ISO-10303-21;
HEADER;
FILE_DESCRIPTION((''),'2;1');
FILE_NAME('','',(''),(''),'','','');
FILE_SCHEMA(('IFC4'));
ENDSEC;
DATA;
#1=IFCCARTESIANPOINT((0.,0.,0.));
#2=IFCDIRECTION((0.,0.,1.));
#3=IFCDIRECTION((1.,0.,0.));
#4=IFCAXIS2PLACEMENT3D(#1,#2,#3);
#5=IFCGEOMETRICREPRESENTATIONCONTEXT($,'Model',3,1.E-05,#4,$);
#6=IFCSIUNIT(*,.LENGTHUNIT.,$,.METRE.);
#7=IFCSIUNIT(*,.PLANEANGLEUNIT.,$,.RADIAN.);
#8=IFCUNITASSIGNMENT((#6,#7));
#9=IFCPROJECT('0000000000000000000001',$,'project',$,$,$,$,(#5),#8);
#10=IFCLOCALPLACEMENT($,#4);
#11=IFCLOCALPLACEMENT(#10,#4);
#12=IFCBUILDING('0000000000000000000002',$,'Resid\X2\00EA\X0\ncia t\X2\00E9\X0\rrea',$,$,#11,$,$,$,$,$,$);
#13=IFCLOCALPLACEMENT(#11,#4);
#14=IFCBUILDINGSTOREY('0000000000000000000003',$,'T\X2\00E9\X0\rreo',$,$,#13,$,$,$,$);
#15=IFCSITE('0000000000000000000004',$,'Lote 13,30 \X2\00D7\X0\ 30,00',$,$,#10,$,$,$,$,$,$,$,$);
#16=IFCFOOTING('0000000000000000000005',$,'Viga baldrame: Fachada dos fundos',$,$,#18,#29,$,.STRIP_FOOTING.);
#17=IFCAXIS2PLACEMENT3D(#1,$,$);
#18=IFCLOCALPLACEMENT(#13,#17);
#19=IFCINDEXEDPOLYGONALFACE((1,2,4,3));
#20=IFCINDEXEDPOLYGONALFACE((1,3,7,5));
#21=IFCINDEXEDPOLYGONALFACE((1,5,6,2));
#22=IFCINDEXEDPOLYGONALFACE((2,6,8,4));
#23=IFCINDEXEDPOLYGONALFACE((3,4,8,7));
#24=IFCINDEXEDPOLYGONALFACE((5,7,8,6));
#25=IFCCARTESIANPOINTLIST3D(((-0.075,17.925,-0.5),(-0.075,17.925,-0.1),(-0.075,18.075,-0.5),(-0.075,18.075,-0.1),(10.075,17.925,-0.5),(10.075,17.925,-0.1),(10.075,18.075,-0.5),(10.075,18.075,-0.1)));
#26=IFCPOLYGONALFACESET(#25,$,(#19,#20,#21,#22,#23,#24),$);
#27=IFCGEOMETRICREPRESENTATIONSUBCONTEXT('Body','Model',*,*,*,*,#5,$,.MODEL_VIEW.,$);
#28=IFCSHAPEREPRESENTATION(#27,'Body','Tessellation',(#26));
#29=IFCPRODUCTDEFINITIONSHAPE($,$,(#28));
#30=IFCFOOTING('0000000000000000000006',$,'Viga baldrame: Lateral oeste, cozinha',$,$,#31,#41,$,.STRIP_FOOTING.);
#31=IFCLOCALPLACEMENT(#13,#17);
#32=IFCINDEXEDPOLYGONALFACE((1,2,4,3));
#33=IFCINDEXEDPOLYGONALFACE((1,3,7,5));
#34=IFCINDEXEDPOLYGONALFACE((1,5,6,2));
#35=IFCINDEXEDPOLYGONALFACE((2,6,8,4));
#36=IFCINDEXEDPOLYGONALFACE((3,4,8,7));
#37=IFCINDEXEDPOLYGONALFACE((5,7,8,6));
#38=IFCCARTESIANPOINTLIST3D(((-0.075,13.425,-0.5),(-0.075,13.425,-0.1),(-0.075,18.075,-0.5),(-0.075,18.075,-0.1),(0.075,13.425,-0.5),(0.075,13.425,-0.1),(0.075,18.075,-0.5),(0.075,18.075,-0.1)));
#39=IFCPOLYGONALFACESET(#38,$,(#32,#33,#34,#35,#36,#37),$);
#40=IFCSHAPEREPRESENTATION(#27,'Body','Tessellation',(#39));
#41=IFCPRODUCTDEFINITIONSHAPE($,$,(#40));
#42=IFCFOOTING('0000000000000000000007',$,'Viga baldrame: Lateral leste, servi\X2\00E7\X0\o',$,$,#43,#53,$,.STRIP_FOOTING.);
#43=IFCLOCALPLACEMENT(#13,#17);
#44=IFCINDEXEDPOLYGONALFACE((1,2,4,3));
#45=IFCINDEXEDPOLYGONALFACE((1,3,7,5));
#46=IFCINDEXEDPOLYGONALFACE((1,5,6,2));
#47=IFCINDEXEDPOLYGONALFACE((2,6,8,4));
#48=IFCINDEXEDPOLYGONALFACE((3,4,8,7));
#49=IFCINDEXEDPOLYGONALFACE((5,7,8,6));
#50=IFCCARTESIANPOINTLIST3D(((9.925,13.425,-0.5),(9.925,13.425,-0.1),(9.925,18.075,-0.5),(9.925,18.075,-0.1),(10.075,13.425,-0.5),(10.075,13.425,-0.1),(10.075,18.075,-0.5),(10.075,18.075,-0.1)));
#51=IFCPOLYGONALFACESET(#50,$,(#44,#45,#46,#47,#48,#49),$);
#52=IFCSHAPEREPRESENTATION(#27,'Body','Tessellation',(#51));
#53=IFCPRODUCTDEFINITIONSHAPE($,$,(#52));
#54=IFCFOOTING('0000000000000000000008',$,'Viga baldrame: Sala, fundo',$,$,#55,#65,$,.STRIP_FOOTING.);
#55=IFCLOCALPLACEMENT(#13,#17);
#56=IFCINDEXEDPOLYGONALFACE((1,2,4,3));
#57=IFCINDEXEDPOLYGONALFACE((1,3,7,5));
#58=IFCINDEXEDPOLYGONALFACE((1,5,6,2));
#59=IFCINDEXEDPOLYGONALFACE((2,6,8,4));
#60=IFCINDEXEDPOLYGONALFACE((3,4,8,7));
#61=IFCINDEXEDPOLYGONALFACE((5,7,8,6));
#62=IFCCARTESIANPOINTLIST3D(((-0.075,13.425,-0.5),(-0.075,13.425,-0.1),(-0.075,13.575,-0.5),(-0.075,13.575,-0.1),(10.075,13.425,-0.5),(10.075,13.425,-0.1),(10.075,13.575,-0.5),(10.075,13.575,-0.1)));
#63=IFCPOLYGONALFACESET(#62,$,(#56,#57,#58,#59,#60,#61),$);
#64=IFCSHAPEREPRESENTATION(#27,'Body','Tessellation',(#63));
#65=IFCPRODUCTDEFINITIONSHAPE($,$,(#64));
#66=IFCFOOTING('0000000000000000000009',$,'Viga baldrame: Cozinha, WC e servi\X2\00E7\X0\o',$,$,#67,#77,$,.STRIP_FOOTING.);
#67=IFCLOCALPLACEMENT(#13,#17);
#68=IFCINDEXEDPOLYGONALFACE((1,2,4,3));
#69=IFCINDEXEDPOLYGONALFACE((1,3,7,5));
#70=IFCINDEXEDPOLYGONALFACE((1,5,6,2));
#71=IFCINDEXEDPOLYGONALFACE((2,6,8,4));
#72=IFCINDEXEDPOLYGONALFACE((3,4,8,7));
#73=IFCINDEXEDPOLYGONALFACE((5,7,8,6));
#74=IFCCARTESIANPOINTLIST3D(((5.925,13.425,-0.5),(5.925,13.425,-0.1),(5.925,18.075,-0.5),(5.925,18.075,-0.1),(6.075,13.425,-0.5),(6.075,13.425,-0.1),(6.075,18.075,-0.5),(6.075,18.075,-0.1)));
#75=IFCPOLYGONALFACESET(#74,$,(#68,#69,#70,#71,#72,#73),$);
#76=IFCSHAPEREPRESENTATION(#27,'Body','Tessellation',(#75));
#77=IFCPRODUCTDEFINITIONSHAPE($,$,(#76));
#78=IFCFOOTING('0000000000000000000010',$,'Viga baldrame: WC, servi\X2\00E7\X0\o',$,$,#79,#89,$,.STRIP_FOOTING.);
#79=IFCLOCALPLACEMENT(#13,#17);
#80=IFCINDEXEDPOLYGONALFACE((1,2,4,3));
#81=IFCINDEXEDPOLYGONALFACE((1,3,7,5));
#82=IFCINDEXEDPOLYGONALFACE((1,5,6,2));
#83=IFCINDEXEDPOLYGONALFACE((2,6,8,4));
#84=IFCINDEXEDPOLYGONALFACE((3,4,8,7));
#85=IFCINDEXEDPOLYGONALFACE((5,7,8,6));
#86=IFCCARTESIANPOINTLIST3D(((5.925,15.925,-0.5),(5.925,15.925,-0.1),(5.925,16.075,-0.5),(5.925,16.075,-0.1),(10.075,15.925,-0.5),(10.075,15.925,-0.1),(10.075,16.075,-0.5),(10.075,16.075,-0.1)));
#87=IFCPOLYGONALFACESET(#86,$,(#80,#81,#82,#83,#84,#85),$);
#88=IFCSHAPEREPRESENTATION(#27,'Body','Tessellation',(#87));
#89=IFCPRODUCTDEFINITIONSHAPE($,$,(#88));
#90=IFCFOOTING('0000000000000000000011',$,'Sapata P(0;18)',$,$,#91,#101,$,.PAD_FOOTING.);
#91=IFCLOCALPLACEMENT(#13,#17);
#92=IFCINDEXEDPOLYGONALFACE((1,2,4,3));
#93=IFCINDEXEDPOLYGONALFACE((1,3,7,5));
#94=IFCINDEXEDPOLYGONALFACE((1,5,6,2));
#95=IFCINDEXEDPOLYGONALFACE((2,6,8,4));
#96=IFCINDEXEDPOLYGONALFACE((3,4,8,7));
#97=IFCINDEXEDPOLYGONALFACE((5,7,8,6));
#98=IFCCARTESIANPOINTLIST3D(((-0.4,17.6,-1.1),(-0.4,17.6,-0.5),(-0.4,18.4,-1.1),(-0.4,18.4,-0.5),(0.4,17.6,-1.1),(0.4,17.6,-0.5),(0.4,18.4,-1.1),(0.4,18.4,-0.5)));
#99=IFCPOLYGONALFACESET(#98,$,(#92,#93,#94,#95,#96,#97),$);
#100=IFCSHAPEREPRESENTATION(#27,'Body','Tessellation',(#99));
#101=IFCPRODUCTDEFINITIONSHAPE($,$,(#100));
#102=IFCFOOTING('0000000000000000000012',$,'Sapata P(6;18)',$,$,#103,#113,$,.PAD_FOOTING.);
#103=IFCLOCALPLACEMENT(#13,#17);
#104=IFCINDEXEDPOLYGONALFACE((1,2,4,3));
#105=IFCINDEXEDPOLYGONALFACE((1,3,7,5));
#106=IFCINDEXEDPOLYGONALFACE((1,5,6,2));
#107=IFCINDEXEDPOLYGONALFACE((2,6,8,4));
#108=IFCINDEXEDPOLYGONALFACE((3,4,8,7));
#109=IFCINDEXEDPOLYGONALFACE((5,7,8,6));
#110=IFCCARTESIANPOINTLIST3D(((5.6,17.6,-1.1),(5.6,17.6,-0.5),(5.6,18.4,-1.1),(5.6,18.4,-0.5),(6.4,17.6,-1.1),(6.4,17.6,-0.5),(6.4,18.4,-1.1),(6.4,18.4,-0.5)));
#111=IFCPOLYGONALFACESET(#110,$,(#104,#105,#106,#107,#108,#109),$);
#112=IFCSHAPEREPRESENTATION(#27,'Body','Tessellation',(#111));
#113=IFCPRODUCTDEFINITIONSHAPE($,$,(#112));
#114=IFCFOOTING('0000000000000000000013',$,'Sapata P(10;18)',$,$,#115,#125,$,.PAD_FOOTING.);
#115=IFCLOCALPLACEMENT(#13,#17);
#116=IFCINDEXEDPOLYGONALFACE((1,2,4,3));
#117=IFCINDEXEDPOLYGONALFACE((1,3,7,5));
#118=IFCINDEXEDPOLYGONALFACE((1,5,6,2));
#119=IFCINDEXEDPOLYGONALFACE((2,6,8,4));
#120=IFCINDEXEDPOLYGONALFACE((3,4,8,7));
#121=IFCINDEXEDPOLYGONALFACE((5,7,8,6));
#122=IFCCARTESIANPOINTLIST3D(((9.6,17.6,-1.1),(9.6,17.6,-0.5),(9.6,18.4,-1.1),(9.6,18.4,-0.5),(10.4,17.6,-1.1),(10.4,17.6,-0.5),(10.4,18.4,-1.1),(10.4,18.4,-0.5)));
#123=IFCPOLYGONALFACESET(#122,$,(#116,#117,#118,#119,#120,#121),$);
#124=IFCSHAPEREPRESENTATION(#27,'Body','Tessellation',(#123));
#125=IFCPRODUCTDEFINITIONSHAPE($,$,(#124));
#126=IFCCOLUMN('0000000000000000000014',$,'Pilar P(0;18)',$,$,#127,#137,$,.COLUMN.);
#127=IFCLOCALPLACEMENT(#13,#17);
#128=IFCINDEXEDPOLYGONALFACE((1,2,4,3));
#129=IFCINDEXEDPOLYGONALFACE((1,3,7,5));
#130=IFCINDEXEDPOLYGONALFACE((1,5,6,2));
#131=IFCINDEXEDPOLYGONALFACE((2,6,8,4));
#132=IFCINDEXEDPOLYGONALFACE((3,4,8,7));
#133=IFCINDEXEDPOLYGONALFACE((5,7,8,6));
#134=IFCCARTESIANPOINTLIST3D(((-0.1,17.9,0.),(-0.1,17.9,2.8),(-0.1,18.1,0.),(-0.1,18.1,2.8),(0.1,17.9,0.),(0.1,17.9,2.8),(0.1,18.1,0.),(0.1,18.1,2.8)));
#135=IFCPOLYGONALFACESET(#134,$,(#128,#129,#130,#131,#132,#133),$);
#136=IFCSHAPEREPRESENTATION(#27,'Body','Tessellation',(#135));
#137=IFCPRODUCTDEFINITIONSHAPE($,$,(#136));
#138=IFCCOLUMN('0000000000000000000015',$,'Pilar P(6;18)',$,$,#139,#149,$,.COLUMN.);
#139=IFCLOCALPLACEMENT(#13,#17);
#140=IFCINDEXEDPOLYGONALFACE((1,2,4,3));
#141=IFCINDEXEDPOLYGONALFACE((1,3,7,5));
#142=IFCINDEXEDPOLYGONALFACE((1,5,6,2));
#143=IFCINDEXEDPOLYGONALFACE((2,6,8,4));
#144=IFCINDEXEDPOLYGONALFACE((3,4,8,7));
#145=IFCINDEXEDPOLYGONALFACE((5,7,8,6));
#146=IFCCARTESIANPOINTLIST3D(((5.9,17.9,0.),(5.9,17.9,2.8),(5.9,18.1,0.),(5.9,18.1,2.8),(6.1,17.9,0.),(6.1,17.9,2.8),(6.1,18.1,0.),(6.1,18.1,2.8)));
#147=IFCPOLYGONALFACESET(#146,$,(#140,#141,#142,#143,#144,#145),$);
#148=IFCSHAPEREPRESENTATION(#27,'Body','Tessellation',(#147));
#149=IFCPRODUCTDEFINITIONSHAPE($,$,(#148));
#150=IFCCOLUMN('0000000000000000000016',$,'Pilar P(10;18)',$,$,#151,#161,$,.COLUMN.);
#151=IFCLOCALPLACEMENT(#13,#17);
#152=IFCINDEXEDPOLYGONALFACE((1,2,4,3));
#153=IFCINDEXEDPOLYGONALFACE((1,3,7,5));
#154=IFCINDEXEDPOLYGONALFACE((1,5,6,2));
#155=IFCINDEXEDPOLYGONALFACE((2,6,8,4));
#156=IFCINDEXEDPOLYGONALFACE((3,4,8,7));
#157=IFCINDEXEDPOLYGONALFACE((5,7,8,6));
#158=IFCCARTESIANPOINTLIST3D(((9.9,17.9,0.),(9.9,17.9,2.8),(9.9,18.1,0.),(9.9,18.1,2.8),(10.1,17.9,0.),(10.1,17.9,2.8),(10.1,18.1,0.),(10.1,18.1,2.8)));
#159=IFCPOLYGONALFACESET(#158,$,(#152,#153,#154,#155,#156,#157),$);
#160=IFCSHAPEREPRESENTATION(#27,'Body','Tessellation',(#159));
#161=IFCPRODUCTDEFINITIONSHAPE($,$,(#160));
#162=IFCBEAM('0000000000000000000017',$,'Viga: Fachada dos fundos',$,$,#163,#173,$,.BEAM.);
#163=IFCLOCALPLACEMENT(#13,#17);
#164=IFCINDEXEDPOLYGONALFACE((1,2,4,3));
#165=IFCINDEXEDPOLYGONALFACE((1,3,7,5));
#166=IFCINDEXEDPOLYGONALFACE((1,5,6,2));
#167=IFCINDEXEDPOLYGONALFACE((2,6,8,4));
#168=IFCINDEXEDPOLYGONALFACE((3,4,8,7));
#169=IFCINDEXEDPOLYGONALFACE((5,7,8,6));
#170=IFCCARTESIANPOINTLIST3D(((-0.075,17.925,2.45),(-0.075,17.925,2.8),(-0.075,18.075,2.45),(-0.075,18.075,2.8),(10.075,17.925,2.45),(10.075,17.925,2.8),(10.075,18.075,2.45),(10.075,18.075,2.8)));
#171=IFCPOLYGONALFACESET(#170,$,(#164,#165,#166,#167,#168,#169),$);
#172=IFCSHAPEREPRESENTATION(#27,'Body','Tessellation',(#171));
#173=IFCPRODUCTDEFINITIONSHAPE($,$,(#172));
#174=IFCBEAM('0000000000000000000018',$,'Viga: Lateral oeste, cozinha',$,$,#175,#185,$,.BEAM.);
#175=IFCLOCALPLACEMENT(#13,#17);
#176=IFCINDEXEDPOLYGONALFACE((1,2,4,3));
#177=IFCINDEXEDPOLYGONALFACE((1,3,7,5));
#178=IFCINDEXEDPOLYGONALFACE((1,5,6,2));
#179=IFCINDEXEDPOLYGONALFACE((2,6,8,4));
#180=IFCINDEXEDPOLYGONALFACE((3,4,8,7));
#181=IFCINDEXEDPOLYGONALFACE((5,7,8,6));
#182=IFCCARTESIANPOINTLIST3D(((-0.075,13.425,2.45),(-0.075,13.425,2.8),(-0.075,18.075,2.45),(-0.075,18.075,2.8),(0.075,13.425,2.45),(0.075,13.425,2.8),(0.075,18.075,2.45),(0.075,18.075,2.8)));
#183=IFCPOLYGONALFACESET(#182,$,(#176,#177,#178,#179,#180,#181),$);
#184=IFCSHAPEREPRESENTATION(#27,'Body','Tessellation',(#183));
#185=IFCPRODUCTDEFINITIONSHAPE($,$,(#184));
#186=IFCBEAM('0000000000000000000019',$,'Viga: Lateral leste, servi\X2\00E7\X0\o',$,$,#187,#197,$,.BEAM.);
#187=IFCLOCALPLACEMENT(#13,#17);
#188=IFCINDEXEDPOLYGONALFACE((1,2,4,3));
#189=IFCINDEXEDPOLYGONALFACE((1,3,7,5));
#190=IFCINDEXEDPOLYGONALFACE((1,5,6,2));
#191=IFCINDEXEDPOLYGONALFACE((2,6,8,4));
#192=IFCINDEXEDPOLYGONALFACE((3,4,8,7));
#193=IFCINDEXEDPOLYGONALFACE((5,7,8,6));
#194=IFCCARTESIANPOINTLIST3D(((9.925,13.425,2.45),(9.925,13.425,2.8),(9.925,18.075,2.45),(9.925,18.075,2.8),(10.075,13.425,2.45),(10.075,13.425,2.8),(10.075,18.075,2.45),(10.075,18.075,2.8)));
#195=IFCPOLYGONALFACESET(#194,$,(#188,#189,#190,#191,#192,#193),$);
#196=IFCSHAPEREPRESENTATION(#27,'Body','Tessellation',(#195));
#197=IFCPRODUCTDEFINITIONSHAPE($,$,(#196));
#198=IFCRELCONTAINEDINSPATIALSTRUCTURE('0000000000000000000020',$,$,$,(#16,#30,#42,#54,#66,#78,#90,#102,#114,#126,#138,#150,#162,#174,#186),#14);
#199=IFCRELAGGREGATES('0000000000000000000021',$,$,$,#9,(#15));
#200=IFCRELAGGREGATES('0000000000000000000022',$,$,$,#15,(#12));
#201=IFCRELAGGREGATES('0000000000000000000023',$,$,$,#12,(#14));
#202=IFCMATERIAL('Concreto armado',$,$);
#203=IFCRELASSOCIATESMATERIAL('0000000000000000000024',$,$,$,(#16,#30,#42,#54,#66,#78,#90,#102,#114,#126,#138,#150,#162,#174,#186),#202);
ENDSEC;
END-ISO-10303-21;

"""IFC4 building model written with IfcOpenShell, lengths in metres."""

from ifc_helpers import new_model, si_unit, frame, origin_with_axes, place, context, subcontext, project, spatial, line, indexed_curve, outline, extrude, material, element, save


model = new_model("IFC4")

# Units and contexts
model_context = context("Model", 3, precision=1e-05, world=origin_with_axes())
body_context = subcontext(model_context, "Body", "Model", "MODEL_VIEW")
ifc_project = project(units=[si_unit("LENGTHUNIT", "METRE"), si_unit("PLANEANGLEUNIT", "RADIAN")], contexts=[model_context])

# Site, building, storey
site_placement = place(None, origin_with_axes())
site = spatial("IfcSite", under=ifc_project, at=site_placement, Name="Lote 13,30 × 30,00")
building_placement = place(site_placement, origin_with_axes())
building = spatial("IfcBuilding", under=site, at=building_placement, Name="Residência térrea")
storey_placement = place(building_placement, origin_with_axes())
storey = spatial("IfcBuildingStorey", under=building, at=storey_placement, Name="Térreo")

# Footings
ifc_material_1 = material(Name="Concreto armado")
footing_1_placement = place(storey_placement, frame((-0.075, 17.925, -0.5), z_axis=(0.0, 0.0, 1.0), x_axis=(1.0, 0.0, 0.0)))
element("IfcFooting", 1, at=footing_1_placement, inside=storey, material=ifc_material_1, Name="Viga baldrame: Fachada dos fundos", PredefinedType="STRIP_FOOTING", context=body_context, shape_type="SweptSolid", body=[
    extrude(outline(indexed_curve([(0.0, 0.0), (10.15, 0.0), (10.15, 0.15), (0.0, 0.15)], segments=[line(1, 2, 3, 4, 1)])), origin_with_axes(), (0.0, 0.0, 1.0), 0.4),
])
footing_2_placement = place(storey_placement, frame((-0.075, 13.425, -0.5), z_axis=(0.0, 0.0, 1.0), x_axis=(1.0, 0.0, 0.0)))
element("IfcFooting", 2, at=footing_2_placement, inside=storey, material=ifc_material_1, Name="Viga baldrame: Lateral oeste, cozinha", PredefinedType="STRIP_FOOTING", context=body_context, shape_type="SweptSolid", body=[
    extrude(outline(indexed_curve([(0.0, 0.0), (0.15, 0.0), (0.15, 4.65), (0.0, 4.65)], segments=[line(1, 2, 3, 4, 1)])), origin_with_axes(), (0.0, 0.0, 1.0), 0.4),
])
footing_3_placement = place(storey_placement, frame((9.925, 13.425, -0.5), z_axis=(0.0, 0.0, 1.0), x_axis=(1.0, 0.0, 0.0)))
element("IfcFooting", 3, at=footing_3_placement, inside=storey, material=ifc_material_1, Name="Viga baldrame: Lateral leste, serviço", PredefinedType="STRIP_FOOTING", context=body_context, shape_type="SweptSolid", body=[
    extrude(outline(indexed_curve([(0.0, 0.0), (0.15, 0.0), (0.15, 4.65), (0.0, 4.65)], segments=[line(1, 2, 3, 4, 1)])), origin_with_axes(), (0.0, 0.0, 1.0), 0.4),
])
footing_4_placement = place(storey_placement, frame((-0.075, 13.425, -0.5), z_axis=(0.0, 0.0, 1.0), x_axis=(1.0, 0.0, 0.0)))
element("IfcFooting", 4, at=footing_4_placement, inside=storey, material=ifc_material_1, Name="Viga baldrame: Sala, fundo", PredefinedType="STRIP_FOOTING", context=body_context, shape_type="SweptSolid", body=[
    extrude(outline(indexed_curve([(0.0, 0.0), (10.15, 0.0), (10.15, 0.15), (0.0, 0.15)], segments=[line(1, 2, 3, 4, 1)])), origin_with_axes(), (0.0, 0.0, 1.0), 0.4),
])
footing_5_placement = place(storey_placement, frame((5.925, 13.425, -0.5), z_axis=(0.0, 0.0, 1.0), x_axis=(1.0, 0.0, 0.0)))
element("IfcFooting", 5, at=footing_5_placement, inside=storey, material=ifc_material_1, Name="Viga baldrame: Cozinha, WC e serviço", PredefinedType="STRIP_FOOTING", context=body_context, shape_type="SweptSolid", body=[
    extrude(outline(indexed_curve([(0.0, 0.0), (0.15, 0.0), (0.15, 4.65), (0.0, 4.65)], segments=[line(1, 2, 3, 4, 1)])), origin_with_axes(), (0.0, 0.0, 1.0), 0.4),
])
footing_6_placement = place(storey_placement, frame((5.925, 15.925, -0.5), z_axis=(0.0, 0.0, 1.0), x_axis=(1.0, 0.0, 0.0)))
element("IfcFooting", 6, at=footing_6_placement, inside=storey, material=ifc_material_1, Name="Viga baldrame: WC, serviço", PredefinedType="STRIP_FOOTING", context=body_context, shape_type="SweptSolid", body=[
    extrude(outline(indexed_curve([(0.0, 0.0), (4.15, 0.0), (4.15, 0.15), (0.0, 0.15)], segments=[line(1, 2, 3, 4, 1)])), origin_with_axes(), (0.0, 0.0, 1.0), 0.4),
])
footing_7_placement = place(storey_placement, frame((-0.4, 17.6, -1.1), z_axis=(0.0, 0.0, 1.0), x_axis=(1.0, 0.0, 0.0)))
element("IfcFooting", 7, at=footing_7_placement, inside=storey, material=ifc_material_1, Name="Sapata P(0;18)", PredefinedType="PAD_FOOTING", context=body_context, shape_type="SweptSolid", body=[
    extrude(outline(indexed_curve([(0.0, 0.0), (0.8, 0.0), (0.8, 0.8), (0.0, 0.8)], segments=[line(1, 2, 3, 4, 1)])), origin_with_axes(), (0.0, 0.0, 1.0), 0.6),
])
for number, where, z_axis, x_axis, name in (
    (8, (5.6, 17.6, -1.1), (0.0, 0.0, 1.0), (1.0, 0.0, 0.0), "Sapata P(6;18)"),
    (9, (9.6, 17.6, -1.1), (0.0, 0.0, 1.0), (1.0, 0.0, 0.0), "Sapata P(10;18)"),
):
    element("IfcFooting", number, at=place(storey_placement, frame(where, z_axis=z_axis, x_axis=x_axis)), inside=storey, material=ifc_material_1, Name=name, PredefinedType="PAD_FOOTING", context=body_context, shape_type="SweptSolid", body=[
        extrude(outline(indexed_curve([(0.0, 0.0), (0.8, 0.0), (0.8, 0.8), (0.0, 0.8)], segments=[line(1, 2, 3, 4, 1)])), origin_with_axes(), (0.0, 0.0, 1.0), 0.6),
    ])

# Columns
column_placement = place(storey_placement, frame((-0.1, 17.9, 0.0), z_axis=(0.0, 0.0, 1.0), x_axis=(1.0, 0.0, 0.0)))
element("IfcColumn", 10, at=column_placement, inside=storey, material=ifc_material_1, Name="Pilar P(0;18)", PredefinedType="COLUMN", context=body_context, shape_type="SweptSolid", body=[
    extrude(outline(indexed_curve([(0.0, 0.0), (0.2, 0.0), (0.2, 0.2), (0.0, 0.2)], segments=[line(1, 2, 3, 4, 1)])), origin_with_axes(), (0.0, 0.0, 1.0), 2.8),
])
for number, where, z_axis, x_axis, name in (
    (11, (5.9, 17.9, 0.0), (0.0, 0.0, 1.0), (1.0, 0.0, 0.0), "Pilar P(6;18)"),
    (12, (9.9, 17.9, 0.0), (0.0, 0.0, 1.0), (1.0, 0.0, 0.0), "Pilar P(10;18)"),
):
    element("IfcColumn", number, at=place(storey_placement, frame(where, z_axis=z_axis, x_axis=x_axis)), inside=storey, material=ifc_material_1, Name=name, PredefinedType="COLUMN", context=body_context, shape_type="SweptSolid", body=[
        extrude(outline(indexed_curve([(0.0, 0.0), (0.2, 0.0), (0.2, 0.2), (0.0, 0.2)], segments=[line(1, 2, 3, 4, 1)])), origin_with_axes(), (0.0, 0.0, 1.0), 2.8),
    ])

# Beams
beam_1_placement = place(storey_placement, frame((-0.075, 17.925, 2.45), z_axis=(0.0, 0.0, 1.0), x_axis=(1.0, 0.0, 0.0)))
element("IfcBeam", 13, at=beam_1_placement, inside=storey, material=ifc_material_1, Name="Viga: Fachada dos fundos", PredefinedType="BEAM", context=body_context, shape_type="SweptSolid", body=[
    extrude(outline(indexed_curve([(0.0, 0.0), (10.15, 0.0), (10.15, 0.15), (0.0, 0.15)], segments=[line(1, 2, 3, 4, 1)])), origin_with_axes(), (0.0, 0.0, 1.0), 0.35),
])
beam_2_placement = place(storey_placement, frame((-0.075, 13.425, 2.45), z_axis=(0.0, 0.0, 1.0), x_axis=(1.0, 0.0, 0.0)))
element("IfcBeam", 14, at=beam_2_placement, inside=storey, material=ifc_material_1, Name="Viga: Lateral oeste, cozinha", PredefinedType="BEAM", context=body_context, shape_type="SweptSolid", body=[
    extrude(outline(indexed_curve([(0.0, 0.0), (0.15, 0.0), (0.15, 4.65), (0.0, 4.65)], segments=[line(1, 2, 3, 4, 1)])), origin_with_axes(), (0.0, 0.0, 1.0), 0.35),
])
beam_3_placement = place(storey_placement, frame((9.925, 13.425, 2.45), z_axis=(0.0, 0.0, 1.0), x_axis=(1.0, 0.0, 0.0)))
element("IfcBeam", 15, at=beam_3_placement, inside=storey, material=ifc_material_1, Name="Viga: Lateral leste, serviço", PredefinedType="BEAM", context=body_context, shape_type="SweptSolid", body=[
    extrude(outline(indexed_curve([(0.0, 0.0), (0.15, 0.0), (0.15, 4.65), (0.0, 4.65)], segments=[line(1, 2, 3, 4, 1)])), origin_with_axes(), (0.0, 0.0, 1.0), 0.35),
])

save(model, "model.ifc")
